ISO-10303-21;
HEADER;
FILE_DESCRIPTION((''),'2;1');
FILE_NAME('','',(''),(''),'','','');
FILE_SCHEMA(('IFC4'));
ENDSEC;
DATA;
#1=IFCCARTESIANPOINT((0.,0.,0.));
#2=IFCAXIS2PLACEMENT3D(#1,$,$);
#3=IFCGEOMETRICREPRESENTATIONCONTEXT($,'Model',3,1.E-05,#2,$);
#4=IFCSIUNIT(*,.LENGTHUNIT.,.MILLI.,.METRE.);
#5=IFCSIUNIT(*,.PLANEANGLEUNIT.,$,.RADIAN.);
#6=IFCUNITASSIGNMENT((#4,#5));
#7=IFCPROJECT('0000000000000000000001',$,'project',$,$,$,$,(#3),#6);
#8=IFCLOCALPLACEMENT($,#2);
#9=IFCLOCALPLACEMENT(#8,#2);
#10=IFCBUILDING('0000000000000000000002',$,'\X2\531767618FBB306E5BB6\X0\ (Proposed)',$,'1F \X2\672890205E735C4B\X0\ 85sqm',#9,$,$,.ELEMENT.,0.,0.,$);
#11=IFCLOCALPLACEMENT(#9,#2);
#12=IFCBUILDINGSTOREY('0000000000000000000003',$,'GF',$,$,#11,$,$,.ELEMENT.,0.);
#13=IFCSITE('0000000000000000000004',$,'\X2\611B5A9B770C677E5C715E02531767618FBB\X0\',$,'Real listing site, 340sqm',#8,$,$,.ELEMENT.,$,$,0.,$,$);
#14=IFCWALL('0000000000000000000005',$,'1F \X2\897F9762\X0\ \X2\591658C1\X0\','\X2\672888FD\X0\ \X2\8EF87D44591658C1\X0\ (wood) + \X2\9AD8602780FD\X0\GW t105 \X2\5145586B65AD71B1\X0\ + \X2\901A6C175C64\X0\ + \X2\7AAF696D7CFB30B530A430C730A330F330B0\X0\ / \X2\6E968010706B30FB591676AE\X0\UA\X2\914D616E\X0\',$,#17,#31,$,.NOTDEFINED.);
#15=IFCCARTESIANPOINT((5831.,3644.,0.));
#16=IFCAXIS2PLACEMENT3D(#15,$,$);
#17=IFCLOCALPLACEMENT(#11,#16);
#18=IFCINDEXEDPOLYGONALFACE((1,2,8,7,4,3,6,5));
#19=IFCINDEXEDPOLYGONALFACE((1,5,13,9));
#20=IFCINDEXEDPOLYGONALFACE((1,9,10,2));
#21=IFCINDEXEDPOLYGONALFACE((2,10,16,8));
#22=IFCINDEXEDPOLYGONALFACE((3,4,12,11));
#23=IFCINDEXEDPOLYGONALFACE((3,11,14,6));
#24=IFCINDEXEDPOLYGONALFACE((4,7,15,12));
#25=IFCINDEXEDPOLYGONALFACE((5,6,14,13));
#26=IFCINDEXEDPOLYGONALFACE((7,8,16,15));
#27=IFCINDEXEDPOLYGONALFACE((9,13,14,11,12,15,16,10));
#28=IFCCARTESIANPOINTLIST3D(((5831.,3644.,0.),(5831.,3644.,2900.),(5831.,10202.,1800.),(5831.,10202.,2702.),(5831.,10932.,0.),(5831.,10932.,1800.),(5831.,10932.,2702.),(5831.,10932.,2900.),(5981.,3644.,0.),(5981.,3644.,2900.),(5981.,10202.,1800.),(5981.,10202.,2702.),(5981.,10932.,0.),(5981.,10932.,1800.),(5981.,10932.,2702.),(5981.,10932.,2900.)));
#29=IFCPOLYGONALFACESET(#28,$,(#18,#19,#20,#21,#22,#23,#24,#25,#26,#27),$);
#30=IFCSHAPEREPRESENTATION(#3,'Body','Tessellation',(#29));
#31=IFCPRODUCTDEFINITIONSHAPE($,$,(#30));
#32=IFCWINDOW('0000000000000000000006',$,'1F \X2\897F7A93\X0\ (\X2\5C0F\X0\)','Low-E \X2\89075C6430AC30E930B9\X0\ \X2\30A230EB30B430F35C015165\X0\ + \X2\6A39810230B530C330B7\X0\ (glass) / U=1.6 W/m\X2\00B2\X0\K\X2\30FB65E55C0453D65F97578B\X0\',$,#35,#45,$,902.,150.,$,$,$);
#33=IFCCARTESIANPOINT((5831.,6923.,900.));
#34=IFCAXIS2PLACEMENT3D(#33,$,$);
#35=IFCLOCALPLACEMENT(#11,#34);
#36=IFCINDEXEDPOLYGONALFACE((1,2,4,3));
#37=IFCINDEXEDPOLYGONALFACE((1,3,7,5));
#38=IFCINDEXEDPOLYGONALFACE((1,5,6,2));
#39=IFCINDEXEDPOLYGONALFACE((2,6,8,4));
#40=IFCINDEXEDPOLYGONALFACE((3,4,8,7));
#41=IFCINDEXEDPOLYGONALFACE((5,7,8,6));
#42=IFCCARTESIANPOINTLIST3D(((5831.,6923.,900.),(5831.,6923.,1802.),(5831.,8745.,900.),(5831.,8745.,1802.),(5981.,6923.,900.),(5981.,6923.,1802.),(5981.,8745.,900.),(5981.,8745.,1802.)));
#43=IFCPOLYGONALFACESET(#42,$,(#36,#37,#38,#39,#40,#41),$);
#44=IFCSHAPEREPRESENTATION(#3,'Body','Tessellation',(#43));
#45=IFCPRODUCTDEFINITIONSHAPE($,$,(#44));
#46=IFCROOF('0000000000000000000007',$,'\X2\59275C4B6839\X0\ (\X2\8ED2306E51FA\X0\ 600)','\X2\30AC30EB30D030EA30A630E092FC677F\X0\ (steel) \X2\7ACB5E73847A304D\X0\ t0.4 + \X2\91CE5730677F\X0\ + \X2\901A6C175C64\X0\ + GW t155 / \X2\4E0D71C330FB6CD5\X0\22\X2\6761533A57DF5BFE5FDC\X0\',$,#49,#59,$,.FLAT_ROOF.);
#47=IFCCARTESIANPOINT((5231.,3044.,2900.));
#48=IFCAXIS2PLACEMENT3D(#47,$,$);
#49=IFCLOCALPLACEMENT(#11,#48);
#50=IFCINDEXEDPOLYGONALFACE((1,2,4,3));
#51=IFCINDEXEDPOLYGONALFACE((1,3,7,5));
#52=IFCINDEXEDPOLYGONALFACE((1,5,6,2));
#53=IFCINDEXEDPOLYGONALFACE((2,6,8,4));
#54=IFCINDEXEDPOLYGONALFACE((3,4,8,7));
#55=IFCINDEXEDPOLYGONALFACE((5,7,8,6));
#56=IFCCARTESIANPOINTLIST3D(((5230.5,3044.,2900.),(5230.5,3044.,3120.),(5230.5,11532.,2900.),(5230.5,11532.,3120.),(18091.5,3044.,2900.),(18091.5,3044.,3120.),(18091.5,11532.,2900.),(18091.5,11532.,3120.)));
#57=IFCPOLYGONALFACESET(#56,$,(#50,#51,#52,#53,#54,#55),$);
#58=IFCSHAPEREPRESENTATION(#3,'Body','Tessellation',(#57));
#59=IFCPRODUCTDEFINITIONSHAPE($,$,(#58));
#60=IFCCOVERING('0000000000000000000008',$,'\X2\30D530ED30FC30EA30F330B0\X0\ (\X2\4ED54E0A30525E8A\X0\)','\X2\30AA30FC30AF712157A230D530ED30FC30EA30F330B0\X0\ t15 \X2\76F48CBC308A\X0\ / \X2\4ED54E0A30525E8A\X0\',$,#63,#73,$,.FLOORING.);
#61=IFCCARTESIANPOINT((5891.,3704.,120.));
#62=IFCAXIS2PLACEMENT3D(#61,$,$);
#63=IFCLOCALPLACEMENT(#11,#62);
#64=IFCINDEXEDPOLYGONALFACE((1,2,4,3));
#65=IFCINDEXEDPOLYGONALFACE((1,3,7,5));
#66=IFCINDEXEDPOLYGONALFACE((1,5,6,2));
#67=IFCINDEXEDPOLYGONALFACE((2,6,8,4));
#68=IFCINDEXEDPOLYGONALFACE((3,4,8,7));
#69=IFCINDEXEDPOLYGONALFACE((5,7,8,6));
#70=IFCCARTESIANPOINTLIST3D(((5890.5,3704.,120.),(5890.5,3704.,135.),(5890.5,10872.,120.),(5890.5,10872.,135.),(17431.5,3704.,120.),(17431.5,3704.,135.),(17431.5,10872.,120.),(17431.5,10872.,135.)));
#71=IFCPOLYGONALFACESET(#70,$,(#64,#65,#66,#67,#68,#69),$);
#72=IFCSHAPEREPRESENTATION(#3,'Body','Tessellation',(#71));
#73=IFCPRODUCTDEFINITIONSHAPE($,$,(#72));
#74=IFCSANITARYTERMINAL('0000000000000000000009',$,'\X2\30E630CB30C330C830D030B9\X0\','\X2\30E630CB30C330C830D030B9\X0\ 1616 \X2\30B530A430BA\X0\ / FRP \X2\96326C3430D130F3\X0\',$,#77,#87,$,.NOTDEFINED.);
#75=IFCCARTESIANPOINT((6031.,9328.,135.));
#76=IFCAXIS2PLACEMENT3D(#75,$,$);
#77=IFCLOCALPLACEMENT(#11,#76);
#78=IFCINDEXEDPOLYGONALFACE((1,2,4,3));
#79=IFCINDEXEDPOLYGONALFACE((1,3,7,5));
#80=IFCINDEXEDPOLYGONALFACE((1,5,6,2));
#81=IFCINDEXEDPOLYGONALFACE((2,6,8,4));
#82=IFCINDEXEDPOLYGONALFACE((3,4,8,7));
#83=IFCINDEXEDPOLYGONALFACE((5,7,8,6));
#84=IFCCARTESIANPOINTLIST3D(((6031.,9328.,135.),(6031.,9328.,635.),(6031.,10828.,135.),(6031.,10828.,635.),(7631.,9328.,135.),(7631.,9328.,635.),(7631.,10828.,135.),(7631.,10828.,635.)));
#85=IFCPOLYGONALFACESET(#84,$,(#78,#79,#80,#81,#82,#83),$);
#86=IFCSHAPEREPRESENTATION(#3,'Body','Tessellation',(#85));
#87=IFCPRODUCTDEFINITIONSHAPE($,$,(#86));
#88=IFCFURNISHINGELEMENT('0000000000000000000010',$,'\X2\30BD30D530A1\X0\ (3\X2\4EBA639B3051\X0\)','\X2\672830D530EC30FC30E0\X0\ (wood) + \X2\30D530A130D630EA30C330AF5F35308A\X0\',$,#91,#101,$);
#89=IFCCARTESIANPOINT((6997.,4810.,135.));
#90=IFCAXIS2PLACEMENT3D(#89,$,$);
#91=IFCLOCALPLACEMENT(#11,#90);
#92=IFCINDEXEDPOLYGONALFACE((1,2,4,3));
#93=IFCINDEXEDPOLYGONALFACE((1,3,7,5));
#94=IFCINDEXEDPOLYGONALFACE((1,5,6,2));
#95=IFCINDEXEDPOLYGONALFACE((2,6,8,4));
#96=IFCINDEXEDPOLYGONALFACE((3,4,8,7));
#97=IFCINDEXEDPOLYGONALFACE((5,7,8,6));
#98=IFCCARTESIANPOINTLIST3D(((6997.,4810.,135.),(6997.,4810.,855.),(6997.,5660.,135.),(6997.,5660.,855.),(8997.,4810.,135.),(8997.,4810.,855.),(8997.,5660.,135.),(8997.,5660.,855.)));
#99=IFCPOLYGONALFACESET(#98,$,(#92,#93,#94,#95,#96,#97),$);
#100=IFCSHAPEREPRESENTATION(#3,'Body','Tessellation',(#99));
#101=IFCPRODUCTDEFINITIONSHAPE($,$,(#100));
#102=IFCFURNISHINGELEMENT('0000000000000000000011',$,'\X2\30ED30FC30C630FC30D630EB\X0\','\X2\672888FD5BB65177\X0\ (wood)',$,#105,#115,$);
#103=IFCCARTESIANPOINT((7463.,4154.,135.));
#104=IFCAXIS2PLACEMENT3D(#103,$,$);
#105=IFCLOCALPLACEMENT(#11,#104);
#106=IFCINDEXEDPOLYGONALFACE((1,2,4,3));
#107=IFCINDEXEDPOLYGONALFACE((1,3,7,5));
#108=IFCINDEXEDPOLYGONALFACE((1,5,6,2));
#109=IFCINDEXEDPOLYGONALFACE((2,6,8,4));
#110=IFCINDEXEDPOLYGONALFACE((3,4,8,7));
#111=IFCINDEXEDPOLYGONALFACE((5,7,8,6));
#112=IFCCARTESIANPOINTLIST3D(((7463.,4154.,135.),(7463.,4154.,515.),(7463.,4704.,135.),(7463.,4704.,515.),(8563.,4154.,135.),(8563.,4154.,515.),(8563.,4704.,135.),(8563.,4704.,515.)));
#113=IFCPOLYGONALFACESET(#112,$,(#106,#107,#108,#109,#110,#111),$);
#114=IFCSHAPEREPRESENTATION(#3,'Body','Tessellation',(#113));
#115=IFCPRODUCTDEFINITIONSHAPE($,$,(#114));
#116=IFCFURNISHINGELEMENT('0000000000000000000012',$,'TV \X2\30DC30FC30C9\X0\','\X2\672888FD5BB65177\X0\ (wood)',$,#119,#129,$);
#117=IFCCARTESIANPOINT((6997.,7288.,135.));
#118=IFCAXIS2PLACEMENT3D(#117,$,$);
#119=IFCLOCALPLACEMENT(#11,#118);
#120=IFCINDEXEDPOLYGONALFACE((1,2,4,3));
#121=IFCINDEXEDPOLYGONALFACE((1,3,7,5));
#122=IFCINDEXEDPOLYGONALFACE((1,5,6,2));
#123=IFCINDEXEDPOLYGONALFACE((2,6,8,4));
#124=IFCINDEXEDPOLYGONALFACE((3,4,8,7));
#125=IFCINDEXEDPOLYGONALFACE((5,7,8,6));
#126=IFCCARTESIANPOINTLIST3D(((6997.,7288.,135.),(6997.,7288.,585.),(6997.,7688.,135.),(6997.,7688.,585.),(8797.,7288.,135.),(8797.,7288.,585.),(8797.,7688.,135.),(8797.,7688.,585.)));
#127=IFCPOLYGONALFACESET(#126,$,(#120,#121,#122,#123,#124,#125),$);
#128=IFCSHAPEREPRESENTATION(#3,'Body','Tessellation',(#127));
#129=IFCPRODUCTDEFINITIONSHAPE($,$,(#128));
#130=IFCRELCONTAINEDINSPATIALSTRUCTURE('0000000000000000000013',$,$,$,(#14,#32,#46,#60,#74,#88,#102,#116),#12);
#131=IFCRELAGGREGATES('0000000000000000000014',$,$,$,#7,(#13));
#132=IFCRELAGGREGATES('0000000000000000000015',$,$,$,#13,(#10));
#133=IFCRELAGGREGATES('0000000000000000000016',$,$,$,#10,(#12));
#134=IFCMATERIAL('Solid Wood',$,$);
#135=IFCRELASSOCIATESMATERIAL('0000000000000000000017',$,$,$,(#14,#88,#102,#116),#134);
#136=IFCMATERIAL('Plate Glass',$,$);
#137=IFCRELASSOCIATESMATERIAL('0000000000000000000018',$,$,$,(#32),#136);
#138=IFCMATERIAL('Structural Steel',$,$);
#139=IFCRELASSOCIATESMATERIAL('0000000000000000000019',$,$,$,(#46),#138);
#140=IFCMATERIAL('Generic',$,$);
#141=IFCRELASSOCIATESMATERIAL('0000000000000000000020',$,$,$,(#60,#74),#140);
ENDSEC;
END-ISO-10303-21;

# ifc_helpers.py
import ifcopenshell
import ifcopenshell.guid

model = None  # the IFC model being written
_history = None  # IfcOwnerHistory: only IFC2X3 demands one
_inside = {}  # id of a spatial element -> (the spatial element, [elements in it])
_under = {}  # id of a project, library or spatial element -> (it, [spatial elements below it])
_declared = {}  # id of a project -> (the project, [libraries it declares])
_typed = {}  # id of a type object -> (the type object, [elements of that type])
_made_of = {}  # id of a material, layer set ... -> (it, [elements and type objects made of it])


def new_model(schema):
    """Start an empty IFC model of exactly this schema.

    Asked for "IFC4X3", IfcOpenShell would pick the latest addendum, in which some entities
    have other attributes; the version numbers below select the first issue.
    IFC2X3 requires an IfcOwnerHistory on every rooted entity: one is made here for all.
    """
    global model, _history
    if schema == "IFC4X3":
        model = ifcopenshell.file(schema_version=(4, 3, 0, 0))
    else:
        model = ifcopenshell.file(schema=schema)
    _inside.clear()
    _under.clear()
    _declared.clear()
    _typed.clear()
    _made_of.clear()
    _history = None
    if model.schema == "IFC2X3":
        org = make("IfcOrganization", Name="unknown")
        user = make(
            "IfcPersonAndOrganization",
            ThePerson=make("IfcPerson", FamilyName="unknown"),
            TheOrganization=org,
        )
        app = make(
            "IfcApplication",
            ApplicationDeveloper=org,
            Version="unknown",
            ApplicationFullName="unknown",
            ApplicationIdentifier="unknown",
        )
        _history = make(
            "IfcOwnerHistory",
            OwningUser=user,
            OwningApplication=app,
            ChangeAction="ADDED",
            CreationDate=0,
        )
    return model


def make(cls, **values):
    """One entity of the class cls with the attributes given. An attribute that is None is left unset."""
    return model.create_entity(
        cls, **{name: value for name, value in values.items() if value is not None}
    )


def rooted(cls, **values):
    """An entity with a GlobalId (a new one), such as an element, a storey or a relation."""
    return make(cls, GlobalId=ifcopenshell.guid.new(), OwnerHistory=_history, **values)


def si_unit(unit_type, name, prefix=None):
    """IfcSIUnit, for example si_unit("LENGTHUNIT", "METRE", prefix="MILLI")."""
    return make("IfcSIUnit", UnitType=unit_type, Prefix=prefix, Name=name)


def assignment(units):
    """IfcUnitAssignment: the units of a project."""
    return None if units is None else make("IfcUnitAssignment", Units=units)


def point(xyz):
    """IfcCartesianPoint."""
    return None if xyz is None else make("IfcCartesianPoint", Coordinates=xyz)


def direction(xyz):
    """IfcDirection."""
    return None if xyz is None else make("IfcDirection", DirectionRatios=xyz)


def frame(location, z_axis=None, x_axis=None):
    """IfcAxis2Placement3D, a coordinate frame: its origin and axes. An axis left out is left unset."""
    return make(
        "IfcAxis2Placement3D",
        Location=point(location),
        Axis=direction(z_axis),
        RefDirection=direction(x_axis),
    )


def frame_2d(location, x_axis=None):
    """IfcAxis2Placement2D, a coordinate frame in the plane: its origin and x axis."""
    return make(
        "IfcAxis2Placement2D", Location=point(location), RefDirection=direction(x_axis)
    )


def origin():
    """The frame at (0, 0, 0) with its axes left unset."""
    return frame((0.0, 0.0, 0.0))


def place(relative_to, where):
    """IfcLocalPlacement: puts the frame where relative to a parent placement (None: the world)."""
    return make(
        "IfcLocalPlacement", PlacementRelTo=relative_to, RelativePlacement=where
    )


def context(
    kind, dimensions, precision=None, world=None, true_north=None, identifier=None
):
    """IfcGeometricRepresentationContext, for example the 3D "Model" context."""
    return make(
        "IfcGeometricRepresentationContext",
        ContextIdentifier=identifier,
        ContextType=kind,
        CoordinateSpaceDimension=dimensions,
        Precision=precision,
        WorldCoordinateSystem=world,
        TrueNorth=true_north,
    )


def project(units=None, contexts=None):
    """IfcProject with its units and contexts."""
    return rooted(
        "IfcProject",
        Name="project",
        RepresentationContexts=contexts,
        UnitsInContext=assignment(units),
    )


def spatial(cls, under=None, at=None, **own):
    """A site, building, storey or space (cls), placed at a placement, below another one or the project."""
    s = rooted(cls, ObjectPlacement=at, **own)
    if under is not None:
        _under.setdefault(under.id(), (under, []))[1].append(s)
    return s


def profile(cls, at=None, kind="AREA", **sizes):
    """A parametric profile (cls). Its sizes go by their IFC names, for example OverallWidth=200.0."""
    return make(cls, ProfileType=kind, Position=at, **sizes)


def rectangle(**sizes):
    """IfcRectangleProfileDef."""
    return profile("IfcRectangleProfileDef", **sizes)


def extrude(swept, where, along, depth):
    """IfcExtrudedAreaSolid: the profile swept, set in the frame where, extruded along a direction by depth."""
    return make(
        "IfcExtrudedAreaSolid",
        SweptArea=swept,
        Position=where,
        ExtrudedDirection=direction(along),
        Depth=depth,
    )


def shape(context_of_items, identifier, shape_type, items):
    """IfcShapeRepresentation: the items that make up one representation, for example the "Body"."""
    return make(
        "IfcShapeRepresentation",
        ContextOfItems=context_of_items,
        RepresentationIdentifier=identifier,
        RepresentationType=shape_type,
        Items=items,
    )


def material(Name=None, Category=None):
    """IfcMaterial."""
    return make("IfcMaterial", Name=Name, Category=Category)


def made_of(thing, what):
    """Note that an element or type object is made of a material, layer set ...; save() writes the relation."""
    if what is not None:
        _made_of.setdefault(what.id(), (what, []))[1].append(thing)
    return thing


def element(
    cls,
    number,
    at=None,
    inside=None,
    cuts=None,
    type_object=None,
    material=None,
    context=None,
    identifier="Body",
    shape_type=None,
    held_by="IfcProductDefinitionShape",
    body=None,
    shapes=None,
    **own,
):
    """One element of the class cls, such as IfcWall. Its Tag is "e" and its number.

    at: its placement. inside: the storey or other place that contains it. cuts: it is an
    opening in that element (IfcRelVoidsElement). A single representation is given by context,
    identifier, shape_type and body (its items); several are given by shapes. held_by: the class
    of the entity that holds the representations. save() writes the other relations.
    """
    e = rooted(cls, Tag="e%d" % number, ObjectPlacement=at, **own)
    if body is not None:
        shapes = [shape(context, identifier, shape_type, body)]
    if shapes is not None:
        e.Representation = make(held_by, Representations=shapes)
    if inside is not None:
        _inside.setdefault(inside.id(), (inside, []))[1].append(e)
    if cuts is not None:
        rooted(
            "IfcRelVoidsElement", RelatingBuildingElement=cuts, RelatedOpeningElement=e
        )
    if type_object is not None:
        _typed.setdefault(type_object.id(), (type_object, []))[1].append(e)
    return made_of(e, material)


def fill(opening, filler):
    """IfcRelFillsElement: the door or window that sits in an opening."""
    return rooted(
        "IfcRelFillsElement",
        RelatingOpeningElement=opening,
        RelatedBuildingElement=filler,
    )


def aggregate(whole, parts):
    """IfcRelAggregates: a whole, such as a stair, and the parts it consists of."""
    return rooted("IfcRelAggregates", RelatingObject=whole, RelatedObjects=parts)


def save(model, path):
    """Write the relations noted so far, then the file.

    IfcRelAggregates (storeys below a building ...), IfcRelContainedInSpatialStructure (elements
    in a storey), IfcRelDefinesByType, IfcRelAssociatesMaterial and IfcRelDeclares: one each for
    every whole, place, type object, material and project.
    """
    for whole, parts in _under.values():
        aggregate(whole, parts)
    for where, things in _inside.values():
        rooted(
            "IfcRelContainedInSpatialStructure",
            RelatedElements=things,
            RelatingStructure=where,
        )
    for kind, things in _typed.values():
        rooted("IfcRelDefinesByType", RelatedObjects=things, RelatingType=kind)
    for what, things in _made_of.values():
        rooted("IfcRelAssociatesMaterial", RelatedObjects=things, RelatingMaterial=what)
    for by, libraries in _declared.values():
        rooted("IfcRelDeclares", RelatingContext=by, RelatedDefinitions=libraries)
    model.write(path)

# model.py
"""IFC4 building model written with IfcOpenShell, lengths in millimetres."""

from ifc_helpers import new_model, si_unit, frame, frame_2d, origin, place, context, project, spatial, rectangle, extrude, material, element, fill, save


model = new_model("IFC4")

# Units and contexts
model_context = context("Model", 3, precision=1e-05, world=origin())
ifc_project = project(units=[si_unit("LENGTHUNIT", "METRE", prefix="MILLI"), si_unit("PLANEANGLEUNIT", "RADIAN")], contexts=[model_context])

# Site, building, storey
site_placement = place(None, origin())
site = spatial("IfcSite", under=ifc_project, at=site_placement, Name="愛媛県松山市北条辻", ObjectType="Real listing site, 340sqm", CompositionType="ELEMENT", RefElevation=0.0)
building_placement = place(site_placement, origin())
building = spatial("IfcBuilding", under=site, at=building_placement, Name="北条辻の家 (Proposed)", ObjectType="1F 木造平屋 85sqm", CompositionType="ELEMENT", ElevationOfRefHeight=0.0, ElevationOfTerrain=0.0)
storey_placement = place(building_placement, origin())
storey = spatial("IfcBuildingStorey", under=building, at=storey_placement, Name="GF", CompositionType="ELEMENT", Elevation=0.0)

# Shared definitions
ifc_material_1 = material(Name="Solid Wood")

# Shared definitions
ifc_material_2 = material(Name="Plate Glass")

# Wall, opening, window
wall_1_placement = place(storey_placement, frame((5831.0, 3644.0, 0.0)))
wall_1 = element("IfcWall", 1, at=wall_1_placement, inside=storey, material=ifc_material_1, Name="1F 西面 外壁", Description="木製 軸組外壁 (wood) + 高性能GW t105 充填断熱 + 通気層 + 窯業系サイディング / 準耐火・外皮UA配慮", PredefinedType="NOTDEFINED", context=model_context, shape_type="SweptSolid", body=[
    extrude(rectangle(XDim=150.0, YDim=7288.0, at=frame_2d((75.0, 3644.0))), frame((5831.0, 3644.0, 0.0)), (0.0, 0.0, 1.0), 2900.0),
])
opening_1_placement = place(storey_placement, frame((5831.0, 6923.0, 900.0)))
opening_1 = element("IfcOpeningElement", 2, at=opening_1_placement, cuts=wall_1, PredefinedType="NOTDEFINED", context=model_context, shape_type="SweptSolid", body=[
    extrude(rectangle(XDim=150.0, YDim=1822.0, at=frame_2d((75.0, 911.0))), frame((5831.0, 6923.0, 900.0)), (0.0, 0.0, 1.0), 902.0),
])
window_1_placement = place(storey_placement, frame((5831.0, 6923.0, 900.0)))
window_1 = element("IfcWindow", 3, at=window_1_placement, inside=storey, material=ifc_material_2, Name="1F 西窓 (小)", Description="Low-E 複層ガラス アルゴン封入 + 樹脂サッシ (glass) / U=1.6 W/m²K・日射取得型", OverallHeight=902.0, OverallWidth=150.0, context=model_context, shape_type="SweptSolid", body=[
    extrude(rectangle(XDim=150.0, YDim=1822.0, at=frame_2d((75.0, 911.0))), frame((5831.0, 6923.0, 900.0)), (0.0, 0.0, 1.0), 902.0),
])
fill(opening_1, window_1)

# Roof
ifc_material_3 = material(Name="Structural Steel")
roof_placement = place(storey_placement, frame((5231.0, 3044.0, 2900.0)))
element("IfcRoof", 4, at=roof_placement, inside=storey, material=ifc_material_3, Name="大屋根 (軒の出 600)", Description="ガルバリウム鋼板 (steel) 立平葺き t0.4 + 野地板 + 通気層 + GW t155 / 不燃・法22条区域対応", PredefinedType="FLAT_ROOF", context=model_context, shape_type="SweptSolid", body=[
    extrude(rectangle(XDim=12861.0, YDim=8488.0, at=frame_2d((6430.0, 4244.0))), frame((5231.0, 3044.0, 2900.0)), (0.0, 0.0, 1.0), 220.0),
])

# Covering
ifc_material_4 = material(Name="Generic")
covering_placement = place(storey_placement, frame((5891.0, 3704.0, 120.0)))
element("IfcCovering", 5, at=covering_placement, inside=storey, material=ifc_material_4, Name="フローリング (仕上げ床)", Description="オーク無垢フローリング t15 直貼り / 仕上げ床", PredefinedType="FLOORING", context=model_context, shape_type="SweptSolid", body=[
    extrude(rectangle(XDim=11541.0, YDim=7168.0, at=frame_2d((5770.0, 3584.0))), frame((5891.0, 3704.0, 120.0)), (0.0, 0.0, 1.0), 15.0),
])

# Sanitary terminal
sanitary_terminal_placement = place(storey_placement, frame((6031.0, 9328.0, 135.0)))
element("IfcSanitaryTerminal", 6, at=sanitary_terminal_placement, inside=storey, material=ifc_material_4, Name="ユニットバス", Description="ユニットバス 1616 サイズ / FRP 防水パン", PredefinedType="NOTDEFINED", context=model_context, shape_type="SweptSolid", body=[
    extrude(rectangle(XDim=1600.0, YDim=1500.0, at=frame_2d((800.0, 750.0))), frame((6031.0, 9328.0, 135.0)), (0.0, 0.0, 1.0), 500.0),
])

# Furnishing elements
furnishing_1_placement = place(storey_placement, frame((6997.0, 4810.0, 135.0)))
element("IfcFurnishingElement", 7, at=furnishing_1_placement, inside=storey, material=ifc_material_1, Name="ソファ (3人掛け)", Description="木フレーム (wood) + ファブリック張り", context=model_context, shape_type="SweptSolid", body=[
    extrude(rectangle(XDim=2000.0, YDim=850.0, at=frame_2d((1000.0, 425.0))), frame((6997.0, 4810.0, 135.0)), (0.0, 0.0, 1.0), 720.0),
])
furnishing_2_placement = place(storey_placement, frame((7463.0, 4154.0, 135.0)))
element("IfcFurnishingElement", 8, at=furnishing_2_placement, inside=storey, material=ifc_material_1, Name="ローテーブル", Description="木製家具 (wood)", context=model_context, shape_type="SweptSolid", body=[
    extrude(rectangle(XDim=1100.0, YDim=550.0, at=frame_2d((550.0, 275.0))), frame((7463.0, 4154.0, 135.0)), (0.0, 0.0, 1.0), 380.0),
])
furnishing_3_placement = place(storey_placement, frame((6997.0, 7288.0, 135.0)))
element("IfcFurnishingElement", 9, at=furnishing_3_placement, inside=storey, material=ifc_material_1, Name="TV ボード", Description="木製家具 (wood)", context=model_context, shape_type="SweptSolid", body=[
    extrude(rectangle(XDim=1800.0, YDim=400.0, at=frame_2d((900.0, 200.0))), frame((6997.0, 7288.0, 135.0)), (0.0, 0.0, 1.0), 450.0),
])

save(model, "model.ifc")
